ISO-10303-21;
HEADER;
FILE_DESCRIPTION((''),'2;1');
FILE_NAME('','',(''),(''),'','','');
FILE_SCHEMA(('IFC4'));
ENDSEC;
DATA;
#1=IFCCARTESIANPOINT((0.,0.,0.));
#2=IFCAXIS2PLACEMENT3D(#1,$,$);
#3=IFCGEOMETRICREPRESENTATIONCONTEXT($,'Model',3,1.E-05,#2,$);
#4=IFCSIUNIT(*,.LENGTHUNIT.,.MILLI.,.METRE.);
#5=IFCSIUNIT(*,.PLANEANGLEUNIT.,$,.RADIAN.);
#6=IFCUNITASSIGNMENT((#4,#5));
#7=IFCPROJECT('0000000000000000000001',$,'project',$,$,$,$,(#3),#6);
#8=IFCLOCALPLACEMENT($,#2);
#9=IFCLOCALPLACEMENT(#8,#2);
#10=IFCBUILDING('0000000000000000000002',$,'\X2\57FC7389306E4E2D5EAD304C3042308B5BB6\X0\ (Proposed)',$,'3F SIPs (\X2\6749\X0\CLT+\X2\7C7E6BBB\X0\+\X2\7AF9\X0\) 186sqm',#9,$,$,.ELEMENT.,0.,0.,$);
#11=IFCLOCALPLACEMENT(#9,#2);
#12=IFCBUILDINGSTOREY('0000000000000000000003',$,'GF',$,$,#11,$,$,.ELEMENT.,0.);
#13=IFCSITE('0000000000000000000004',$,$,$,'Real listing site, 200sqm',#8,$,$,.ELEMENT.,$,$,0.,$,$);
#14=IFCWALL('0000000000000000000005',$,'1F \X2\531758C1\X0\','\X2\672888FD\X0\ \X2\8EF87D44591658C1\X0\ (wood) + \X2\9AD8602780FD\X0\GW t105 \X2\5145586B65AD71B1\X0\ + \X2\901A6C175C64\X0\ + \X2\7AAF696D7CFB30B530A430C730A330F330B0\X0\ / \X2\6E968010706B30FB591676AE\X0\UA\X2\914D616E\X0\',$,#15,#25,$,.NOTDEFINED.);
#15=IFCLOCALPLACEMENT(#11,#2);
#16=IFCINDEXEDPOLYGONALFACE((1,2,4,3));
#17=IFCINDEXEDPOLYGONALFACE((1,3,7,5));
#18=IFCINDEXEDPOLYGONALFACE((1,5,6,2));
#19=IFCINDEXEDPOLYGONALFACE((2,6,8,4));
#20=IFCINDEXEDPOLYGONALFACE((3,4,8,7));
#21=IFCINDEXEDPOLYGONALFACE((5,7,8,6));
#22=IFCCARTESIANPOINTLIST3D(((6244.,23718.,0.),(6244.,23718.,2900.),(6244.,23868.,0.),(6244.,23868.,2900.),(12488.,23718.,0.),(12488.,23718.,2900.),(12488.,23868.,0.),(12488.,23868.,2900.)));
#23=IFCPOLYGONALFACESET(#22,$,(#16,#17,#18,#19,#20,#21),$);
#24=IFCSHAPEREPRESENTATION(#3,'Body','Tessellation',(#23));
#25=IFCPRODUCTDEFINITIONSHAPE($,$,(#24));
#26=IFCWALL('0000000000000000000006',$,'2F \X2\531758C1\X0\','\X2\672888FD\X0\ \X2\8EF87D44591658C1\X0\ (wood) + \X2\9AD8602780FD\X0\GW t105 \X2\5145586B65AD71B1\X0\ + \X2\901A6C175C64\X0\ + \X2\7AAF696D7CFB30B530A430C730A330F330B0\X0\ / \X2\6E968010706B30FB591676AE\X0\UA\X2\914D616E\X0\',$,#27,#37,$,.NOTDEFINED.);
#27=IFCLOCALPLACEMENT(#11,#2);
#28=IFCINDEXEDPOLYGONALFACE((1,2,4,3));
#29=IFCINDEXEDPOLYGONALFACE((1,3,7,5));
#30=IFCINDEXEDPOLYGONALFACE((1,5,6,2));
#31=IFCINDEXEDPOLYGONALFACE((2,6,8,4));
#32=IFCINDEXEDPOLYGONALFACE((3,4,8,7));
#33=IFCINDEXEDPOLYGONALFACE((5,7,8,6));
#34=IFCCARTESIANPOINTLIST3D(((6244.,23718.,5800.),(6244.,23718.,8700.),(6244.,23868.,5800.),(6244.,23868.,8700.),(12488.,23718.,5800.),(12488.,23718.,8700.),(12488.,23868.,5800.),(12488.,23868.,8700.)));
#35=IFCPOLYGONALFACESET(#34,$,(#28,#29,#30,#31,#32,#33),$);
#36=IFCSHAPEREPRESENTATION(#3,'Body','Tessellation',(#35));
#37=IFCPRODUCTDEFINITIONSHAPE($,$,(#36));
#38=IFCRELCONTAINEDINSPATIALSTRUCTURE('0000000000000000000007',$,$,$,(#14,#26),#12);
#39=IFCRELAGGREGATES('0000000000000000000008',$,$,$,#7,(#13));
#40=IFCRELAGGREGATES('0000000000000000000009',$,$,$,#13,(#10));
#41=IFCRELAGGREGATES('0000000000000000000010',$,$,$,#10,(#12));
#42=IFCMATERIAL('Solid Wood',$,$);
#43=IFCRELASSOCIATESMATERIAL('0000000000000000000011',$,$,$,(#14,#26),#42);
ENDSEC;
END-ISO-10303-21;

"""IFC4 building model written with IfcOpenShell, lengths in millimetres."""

from ifc_helpers import new_model, si_unit, frame, frame_2d, origin, place, context, project, spatial, rectangle, extrude, material, element, save


model = new_model("IFC4")

# Units and contexts
model_context = context("Model", 3, precision=1e-05, world=origin())
ifc_project = project(units=[si_unit("LENGTHUNIT", "METRE", prefix="MILLI"), si_unit("PLANEANGLEUNIT", "RADIAN")], contexts=[model_context])

# Site, building, storey
site_placement = place(None, origin())
site = spatial("IfcSite", under=ifc_project, at=site_placement, ObjectType="Real listing site, 200sqm", CompositionType="ELEMENT", RefElevation=0.0)
building_placement = place(site_placement, origin())
building = spatial("IfcBuilding", under=site, at=building_placement, Name="埼玉の中庭がある家 (Proposed)", ObjectType="3F SIPs (杉CLT+籾殻+竹) 186sqm", CompositionType="ELEMENT", ElevationOfRefHeight=0.0, ElevationOfTerrain=0.0)
storey_placement = place(building_placement, origin())
storey = spatial("IfcBuildingStorey", under=building, at=storey_placement, Name="GF", CompositionType="ELEMENT", Elevation=0.0)

# Shared definitions
ifc_material_1 = material(Name="Solid Wood")

# Wall
wall_1_placement = place(storey_placement, frame((3122.0, 11859.0, 0.0)))
element("IfcWall", 1, at=wall_1_placement, inside=storey, material=ifc_material_1, Name="1F 北壁", Description="木製 軸組外壁 (wood) + 高性能GW t105 充填断熱 + 通気層 + 窯業系サイディング / 準耐火・外皮UA配慮", PredefinedType="NOTDEFINED", context=model_context, shape_type="SweptSolid", body=[
    extrude(rectangle(XDim=6244.0, YDim=150.0, at=frame_2d((3122.0, 75.0))), frame((3122.0, 11859.0, 0.0)), (0.0, 0.0, 1.0), 2900.0),
])

# Wall
wall_2_placement = place(storey_placement, frame((3122.0, 11859.0, 2900.0)))
element("IfcWall", 2, at=wall_2_placement, inside=storey, material=ifc_material_1, Name="2F 北壁", Description="木製 軸組外壁 (wood) + 高性能GW t105 充填断熱 + 通気層 + 窯業系サイディング / 準耐火・外皮UA配慮", PredefinedType="NOTDEFINED", context=model_context, shape_type="SweptSolid", body=[
    extrude(rectangle(XDim=6244.0, YDim=150.0, at=frame_2d((3122.0, 75.0))), frame((3122.0, 11859.0, 2900.0)), (0.0, 0.0, 1.0), 2900.0),
])

save(model, "model.ifc")
